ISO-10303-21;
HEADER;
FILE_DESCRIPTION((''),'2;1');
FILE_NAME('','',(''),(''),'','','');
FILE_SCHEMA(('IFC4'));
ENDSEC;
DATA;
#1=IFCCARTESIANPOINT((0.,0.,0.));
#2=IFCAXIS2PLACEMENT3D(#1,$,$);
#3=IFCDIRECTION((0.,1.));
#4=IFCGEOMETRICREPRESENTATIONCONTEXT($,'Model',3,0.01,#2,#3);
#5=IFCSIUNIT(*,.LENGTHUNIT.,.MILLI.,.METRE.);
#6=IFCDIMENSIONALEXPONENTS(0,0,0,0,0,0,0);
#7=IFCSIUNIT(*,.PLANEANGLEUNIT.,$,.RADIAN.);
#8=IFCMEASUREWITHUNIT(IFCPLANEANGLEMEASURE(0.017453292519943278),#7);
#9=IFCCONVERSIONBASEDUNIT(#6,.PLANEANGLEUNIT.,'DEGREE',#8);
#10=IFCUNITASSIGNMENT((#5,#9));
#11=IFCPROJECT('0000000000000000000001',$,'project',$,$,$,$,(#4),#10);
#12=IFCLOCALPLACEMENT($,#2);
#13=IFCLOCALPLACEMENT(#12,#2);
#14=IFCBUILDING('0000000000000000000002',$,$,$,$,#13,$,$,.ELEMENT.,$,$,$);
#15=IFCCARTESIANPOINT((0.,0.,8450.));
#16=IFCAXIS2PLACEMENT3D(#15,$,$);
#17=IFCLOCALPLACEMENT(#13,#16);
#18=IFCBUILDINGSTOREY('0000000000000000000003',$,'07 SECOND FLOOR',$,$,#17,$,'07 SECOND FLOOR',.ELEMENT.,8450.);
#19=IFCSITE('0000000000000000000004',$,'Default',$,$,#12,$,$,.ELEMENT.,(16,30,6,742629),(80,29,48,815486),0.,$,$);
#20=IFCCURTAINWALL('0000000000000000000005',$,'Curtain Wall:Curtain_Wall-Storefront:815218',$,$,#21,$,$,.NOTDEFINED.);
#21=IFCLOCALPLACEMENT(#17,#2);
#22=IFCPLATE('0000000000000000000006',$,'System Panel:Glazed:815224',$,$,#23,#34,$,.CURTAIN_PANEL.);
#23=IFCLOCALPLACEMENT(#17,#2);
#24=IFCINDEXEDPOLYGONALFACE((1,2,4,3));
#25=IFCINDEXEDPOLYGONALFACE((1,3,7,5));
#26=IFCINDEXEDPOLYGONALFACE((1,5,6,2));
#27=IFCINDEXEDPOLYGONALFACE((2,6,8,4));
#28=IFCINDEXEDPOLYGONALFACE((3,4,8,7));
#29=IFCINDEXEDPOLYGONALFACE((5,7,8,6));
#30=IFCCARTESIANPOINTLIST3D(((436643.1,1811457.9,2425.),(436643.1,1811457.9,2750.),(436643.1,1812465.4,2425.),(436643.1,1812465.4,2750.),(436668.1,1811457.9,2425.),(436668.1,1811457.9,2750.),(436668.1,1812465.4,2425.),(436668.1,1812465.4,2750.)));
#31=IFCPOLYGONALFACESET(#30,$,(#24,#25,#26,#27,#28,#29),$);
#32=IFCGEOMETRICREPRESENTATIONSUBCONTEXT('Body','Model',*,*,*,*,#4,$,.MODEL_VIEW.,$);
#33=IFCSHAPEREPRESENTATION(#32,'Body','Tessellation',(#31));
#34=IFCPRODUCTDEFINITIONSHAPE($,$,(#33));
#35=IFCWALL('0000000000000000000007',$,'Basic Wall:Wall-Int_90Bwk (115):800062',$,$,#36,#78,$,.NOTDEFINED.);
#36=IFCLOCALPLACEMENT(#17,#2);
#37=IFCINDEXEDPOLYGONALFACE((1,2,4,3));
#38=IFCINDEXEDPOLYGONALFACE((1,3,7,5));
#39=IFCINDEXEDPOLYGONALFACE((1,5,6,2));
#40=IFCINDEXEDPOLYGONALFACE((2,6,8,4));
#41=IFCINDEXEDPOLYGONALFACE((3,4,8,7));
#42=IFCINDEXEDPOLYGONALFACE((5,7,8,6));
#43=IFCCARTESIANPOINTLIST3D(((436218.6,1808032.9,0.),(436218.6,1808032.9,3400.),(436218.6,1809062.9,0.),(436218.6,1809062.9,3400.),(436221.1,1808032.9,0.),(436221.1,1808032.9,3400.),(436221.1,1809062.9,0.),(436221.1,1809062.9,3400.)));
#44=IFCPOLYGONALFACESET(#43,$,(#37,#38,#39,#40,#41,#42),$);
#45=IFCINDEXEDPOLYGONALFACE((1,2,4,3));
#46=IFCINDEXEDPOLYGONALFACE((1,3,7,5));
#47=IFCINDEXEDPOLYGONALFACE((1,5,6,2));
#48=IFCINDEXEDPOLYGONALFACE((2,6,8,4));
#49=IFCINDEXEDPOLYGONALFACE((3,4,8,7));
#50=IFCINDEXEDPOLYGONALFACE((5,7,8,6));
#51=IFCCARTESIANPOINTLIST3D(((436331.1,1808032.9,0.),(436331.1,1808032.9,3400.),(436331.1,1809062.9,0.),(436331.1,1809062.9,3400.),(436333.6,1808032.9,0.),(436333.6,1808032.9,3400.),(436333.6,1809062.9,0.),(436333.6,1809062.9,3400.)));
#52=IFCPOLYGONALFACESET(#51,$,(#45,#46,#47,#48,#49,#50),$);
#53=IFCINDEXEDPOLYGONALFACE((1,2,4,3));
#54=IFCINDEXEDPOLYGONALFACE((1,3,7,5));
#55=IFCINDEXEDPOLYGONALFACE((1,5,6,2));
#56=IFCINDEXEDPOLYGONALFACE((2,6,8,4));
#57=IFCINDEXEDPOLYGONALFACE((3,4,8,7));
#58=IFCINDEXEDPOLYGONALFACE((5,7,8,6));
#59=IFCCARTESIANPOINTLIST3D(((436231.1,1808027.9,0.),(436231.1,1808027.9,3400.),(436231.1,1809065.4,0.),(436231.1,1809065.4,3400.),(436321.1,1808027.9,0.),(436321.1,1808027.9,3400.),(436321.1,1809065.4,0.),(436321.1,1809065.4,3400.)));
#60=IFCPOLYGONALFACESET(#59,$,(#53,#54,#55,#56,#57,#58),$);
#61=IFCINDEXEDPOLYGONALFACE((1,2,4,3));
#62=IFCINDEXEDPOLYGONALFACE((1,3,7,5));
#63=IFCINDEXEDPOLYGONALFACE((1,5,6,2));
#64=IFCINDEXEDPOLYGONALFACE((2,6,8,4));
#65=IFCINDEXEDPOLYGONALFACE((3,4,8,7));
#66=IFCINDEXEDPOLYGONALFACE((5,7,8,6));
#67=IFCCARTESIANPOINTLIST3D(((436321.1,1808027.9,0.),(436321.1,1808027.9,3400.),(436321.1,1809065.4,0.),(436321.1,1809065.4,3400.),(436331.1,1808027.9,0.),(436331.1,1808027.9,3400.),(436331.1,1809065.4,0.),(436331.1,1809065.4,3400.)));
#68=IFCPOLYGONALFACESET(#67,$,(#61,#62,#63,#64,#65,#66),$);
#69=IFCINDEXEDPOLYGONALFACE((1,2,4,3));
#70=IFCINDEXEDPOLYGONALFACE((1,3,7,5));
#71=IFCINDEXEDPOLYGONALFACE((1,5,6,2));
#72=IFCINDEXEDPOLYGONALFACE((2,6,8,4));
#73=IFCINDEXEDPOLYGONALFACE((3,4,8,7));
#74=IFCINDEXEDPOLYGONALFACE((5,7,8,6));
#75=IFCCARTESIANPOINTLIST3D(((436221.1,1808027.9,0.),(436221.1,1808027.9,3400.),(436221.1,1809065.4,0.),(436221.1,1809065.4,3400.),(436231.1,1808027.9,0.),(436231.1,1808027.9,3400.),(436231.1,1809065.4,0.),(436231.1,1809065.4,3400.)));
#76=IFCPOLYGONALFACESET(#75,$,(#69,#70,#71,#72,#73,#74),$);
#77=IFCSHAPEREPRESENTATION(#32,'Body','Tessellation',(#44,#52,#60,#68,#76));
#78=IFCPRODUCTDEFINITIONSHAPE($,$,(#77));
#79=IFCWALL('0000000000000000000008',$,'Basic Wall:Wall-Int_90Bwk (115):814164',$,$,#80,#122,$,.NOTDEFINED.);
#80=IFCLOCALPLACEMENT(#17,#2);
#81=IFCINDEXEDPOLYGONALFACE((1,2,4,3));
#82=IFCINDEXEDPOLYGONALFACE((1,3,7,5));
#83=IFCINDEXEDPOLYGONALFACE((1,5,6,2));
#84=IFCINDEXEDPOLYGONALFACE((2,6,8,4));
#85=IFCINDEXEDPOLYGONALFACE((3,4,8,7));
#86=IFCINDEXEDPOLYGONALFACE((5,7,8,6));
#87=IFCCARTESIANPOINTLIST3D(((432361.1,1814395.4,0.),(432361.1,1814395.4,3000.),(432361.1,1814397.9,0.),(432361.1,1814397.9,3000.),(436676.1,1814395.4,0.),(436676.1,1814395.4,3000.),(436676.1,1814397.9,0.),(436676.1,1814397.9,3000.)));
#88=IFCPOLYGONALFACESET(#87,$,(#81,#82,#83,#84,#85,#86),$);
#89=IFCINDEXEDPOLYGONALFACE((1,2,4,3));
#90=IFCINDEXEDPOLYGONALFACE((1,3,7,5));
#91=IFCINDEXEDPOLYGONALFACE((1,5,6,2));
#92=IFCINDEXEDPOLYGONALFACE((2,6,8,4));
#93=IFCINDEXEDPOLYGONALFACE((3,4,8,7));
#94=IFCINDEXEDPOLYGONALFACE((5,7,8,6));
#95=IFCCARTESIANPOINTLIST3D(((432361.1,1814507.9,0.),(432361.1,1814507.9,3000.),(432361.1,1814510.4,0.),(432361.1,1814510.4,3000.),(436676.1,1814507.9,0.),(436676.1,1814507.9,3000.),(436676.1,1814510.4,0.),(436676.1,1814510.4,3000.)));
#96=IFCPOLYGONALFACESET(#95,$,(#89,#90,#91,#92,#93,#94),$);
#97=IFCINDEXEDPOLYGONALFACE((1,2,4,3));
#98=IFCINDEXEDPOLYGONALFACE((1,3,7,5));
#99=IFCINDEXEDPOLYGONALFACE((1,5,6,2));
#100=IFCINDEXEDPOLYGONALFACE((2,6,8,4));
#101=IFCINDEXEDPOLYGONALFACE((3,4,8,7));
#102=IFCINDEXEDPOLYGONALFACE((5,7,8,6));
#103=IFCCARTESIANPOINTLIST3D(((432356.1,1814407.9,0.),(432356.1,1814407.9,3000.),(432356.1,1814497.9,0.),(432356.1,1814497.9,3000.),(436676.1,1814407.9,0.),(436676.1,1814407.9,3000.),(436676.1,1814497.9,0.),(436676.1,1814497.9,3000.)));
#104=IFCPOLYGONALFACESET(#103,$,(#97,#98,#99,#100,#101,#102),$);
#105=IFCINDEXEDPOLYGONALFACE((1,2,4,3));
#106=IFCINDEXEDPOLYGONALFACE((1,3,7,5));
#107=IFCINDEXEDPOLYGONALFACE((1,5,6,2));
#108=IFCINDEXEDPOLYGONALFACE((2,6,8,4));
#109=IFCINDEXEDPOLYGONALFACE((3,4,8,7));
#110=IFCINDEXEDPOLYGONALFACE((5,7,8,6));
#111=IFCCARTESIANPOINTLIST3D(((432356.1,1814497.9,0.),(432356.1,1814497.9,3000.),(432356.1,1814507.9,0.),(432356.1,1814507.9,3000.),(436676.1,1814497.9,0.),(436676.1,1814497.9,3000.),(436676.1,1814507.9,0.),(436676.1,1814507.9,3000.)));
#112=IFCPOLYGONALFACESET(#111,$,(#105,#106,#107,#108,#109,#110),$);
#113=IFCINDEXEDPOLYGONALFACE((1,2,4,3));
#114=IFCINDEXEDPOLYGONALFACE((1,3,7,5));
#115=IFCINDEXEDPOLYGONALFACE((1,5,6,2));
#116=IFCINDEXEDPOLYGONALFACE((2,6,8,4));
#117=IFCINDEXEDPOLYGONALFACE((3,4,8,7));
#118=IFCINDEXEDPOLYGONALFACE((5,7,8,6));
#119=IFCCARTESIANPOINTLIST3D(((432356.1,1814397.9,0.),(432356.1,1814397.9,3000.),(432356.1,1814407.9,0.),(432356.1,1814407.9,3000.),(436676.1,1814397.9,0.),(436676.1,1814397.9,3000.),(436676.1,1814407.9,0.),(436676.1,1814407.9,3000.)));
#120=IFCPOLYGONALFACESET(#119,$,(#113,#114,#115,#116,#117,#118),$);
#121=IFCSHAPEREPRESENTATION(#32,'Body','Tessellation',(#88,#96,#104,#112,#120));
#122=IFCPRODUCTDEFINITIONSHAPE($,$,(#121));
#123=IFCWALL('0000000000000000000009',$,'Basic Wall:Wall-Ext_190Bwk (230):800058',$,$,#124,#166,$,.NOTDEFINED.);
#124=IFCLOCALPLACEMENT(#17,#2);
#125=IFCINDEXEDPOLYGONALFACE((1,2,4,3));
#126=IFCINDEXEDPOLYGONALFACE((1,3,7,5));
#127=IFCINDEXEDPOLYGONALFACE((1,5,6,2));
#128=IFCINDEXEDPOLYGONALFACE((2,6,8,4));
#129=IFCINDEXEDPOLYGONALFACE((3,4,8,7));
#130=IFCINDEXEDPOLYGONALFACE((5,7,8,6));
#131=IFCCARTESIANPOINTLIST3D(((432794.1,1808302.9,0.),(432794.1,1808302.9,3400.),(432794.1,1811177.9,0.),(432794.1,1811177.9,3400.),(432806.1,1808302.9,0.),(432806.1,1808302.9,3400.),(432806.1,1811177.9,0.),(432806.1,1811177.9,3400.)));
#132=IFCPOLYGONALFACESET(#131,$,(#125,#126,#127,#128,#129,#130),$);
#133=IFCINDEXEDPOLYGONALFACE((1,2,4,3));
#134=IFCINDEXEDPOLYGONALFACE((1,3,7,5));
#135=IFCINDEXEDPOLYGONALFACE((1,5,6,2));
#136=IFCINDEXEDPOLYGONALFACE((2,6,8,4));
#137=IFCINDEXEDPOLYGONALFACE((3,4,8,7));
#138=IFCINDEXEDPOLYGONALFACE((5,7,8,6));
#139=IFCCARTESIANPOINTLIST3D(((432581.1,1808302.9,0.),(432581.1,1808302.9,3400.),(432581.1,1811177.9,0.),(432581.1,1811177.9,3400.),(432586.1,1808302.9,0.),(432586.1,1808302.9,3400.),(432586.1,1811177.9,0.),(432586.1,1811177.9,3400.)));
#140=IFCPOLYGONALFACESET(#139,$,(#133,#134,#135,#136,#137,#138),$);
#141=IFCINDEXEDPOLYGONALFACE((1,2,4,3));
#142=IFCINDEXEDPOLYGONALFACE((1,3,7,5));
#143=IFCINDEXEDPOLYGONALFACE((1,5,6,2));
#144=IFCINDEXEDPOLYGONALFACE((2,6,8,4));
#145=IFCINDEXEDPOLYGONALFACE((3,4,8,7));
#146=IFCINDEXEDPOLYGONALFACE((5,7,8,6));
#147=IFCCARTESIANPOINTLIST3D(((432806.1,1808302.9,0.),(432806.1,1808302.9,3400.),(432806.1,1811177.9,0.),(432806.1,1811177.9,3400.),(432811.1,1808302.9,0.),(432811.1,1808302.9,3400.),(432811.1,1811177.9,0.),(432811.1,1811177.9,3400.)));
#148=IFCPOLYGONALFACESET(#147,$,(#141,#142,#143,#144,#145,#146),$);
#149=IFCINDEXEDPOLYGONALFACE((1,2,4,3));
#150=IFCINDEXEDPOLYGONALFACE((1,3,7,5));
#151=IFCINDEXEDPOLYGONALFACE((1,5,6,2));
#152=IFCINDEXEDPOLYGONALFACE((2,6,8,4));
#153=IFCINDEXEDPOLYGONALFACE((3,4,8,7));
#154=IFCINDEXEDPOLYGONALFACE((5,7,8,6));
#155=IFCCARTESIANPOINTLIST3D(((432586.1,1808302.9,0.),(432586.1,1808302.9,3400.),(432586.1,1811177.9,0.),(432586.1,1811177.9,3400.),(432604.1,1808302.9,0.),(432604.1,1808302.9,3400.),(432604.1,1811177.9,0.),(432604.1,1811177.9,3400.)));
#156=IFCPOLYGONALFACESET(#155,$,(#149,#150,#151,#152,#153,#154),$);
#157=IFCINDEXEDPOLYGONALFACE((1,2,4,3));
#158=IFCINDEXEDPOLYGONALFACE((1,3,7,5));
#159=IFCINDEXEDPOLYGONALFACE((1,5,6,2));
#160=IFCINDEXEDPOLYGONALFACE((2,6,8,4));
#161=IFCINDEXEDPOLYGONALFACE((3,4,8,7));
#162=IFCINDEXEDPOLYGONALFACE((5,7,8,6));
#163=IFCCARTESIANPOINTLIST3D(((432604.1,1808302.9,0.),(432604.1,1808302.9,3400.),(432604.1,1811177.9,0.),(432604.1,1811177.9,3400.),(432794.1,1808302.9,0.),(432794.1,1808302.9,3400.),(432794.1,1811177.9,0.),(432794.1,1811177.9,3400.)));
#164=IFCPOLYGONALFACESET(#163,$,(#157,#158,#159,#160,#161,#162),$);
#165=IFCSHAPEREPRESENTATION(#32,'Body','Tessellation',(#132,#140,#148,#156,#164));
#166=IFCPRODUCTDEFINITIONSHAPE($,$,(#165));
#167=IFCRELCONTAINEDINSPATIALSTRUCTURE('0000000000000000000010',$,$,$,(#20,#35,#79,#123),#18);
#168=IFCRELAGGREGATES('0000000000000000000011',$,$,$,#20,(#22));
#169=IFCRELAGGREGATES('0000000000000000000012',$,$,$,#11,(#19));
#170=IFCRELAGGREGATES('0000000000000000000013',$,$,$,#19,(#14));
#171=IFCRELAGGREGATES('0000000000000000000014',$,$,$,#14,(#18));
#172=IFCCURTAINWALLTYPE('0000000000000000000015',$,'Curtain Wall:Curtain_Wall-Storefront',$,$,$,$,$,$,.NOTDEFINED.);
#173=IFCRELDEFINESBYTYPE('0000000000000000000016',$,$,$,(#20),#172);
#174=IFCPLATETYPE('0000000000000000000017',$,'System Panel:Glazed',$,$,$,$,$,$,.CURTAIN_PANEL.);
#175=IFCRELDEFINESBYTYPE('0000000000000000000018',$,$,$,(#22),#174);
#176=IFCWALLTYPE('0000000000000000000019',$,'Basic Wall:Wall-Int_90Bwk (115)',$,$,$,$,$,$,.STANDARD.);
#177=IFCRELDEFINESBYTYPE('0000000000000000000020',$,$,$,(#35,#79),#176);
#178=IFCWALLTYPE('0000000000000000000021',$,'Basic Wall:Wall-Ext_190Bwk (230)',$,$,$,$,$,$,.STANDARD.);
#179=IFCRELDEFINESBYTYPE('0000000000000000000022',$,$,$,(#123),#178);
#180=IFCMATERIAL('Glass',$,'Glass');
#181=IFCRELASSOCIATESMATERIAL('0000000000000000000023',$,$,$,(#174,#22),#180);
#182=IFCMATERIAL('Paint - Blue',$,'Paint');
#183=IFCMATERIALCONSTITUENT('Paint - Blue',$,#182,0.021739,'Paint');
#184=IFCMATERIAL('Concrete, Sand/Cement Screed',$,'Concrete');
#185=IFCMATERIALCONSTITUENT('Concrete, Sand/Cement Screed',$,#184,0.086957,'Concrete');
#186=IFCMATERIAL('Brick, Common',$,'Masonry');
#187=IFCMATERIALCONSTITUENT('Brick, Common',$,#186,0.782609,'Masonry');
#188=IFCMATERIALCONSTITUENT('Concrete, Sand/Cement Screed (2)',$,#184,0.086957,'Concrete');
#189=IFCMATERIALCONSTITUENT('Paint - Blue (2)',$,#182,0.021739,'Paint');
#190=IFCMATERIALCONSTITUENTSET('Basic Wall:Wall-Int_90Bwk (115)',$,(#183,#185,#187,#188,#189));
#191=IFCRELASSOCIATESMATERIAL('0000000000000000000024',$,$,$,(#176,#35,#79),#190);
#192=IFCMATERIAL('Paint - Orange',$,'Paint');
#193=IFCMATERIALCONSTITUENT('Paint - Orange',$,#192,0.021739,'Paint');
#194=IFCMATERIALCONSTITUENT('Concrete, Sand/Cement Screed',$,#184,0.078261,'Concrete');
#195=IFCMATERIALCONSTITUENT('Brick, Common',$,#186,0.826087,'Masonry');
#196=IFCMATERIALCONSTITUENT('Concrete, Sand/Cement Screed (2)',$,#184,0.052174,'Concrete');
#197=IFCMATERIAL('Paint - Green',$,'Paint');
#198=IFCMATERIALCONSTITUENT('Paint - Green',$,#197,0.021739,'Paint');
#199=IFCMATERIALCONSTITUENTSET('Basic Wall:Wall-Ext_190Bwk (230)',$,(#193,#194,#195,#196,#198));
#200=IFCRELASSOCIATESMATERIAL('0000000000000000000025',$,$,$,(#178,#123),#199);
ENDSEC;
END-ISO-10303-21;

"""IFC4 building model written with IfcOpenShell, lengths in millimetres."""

from ifc_helpers import new_model, entity, si_unit, converted_unit, direction, frame, origin, place, context, subcontext, project, spatial, indexed_curve, outline, extrude, source, transform, mapped, material, constituent, constituent_set, type_object, type_shapes, element, aggregate, save


model = new_model("IFC4")

# Units and contexts
model_context = context("Model", 3, precision=0.01, world=origin(), true_north=direction((0.0, 1.0)))
body_context = subcontext(model_context, "Body", "Model", "MODEL_VIEW")
ifc_project = project(units=[si_unit("LENGTHUNIT", "METRE", prefix="MILLI"), converted_unit("PLANEANGLEUNIT", "DEGREE", entity("IfcPlaneAngleMeasure", 0.017453292519943278), si_unit("PLANEANGLEUNIT", "RADIAN"), dimensions=[0, 0, 0, 0, 0, 0, 0])], contexts=[model_context])

# Site, building, storey
site_placement = place(None, origin())
site = spatial("IfcSite", under=ifc_project, at=site_placement, Name="Default", CompositionType="ELEMENT", RefLatitude=(16, 30, 6, 742629), RefLongitude=(80, 29, 48, 815486), RefElevation=0.0)
building_placement = place(site_placement, origin())
building = spatial("IfcBuilding", under=site, at=building_placement, CompositionType="ELEMENT")
storey_placement = place(building_placement, frame((0.0, 0.0, 8450.0)))
storey = spatial("IfcBuildingStorey", under=building, at=storey_placement, Name="07 SECOND FLOOR", LongName="07 SECOND FLOOR", CompositionType="ELEMENT", Elevation=8450.0)

# Curtain wall, plate
curtain_wall_type = type_object("IfcCurtainWallType", Name="Curtain Wall:Curtain_Wall-Storefront", PredefinedType="NOTDEFINED")
curtain_wall_placement = place(storey_placement, frame((0.0, 0.0, -8450.0)))
curtain_wall = element("IfcCurtainWall", 1, at=curtain_wall_placement, inside=storey, type_object=curtain_wall_type, Name="Curtain Wall:Curtain_Wall-Storefront:815218", PredefinedType="NOTDEFINED")
ifc_material_1 = material(Name="Glass", Category="Glass")
plate_type_1 = type_object("IfcPlateType", Name="System Panel:Glazed", PredefinedType="CURTAIN_PANEL", material=ifc_material_1)
shared_shape_1 = source(origin(), body_context, "Body", "SweptSolid", [
    extrude(outline(indexed_curve([(-12.5, -503.8), (12.5, -503.8), (12.5, 503.8), (-12.5, 503.8), (-12.5, -503.8)], self_intersect=False)), frame((0.0, 37.0, 0.0), z_axis=(0.0, 0.0, 1.0), x_axis=(0.0, 1.0, 0.0)), (0.0, 0.0, 1.0), 325.0),
])
type_shapes(plate_type_1, [shared_shape_1])
plate_1_placement = place(curtain_wall_placement, frame((436618.6, 1811961.7, 10875.0), z_axis=(0.0, 0.0, 1.0), x_axis=(0.0, -1.0, 0.0)))
plate_1 = element("IfcPlate", 2, at=plate_1_placement, type_object=plate_type_1, material=ifc_material_1, Name="System Panel:Glazed:815224", PredefinedType="CURTAIN_PANEL", context=body_context, shape_type="MappedRepresentation", body=[
    mapped(shared_shape_1, transform((0.0, 0.0, 0.0), scale=1.0)),
])

# Shared definitions
ifc_material_2 = material(Name="Paint - Blue", Category="Paint")
ifc_constituent_1 = constituent(ifc_material_2, Name="Paint - Blue", Category="Paint", fraction=0.021739)
ifc_material_3 = material(Name="Concrete, Sand/Cement Screed", Category="Concrete")
ifc_constituent_2 = constituent(ifc_material_3, Name="Concrete, Sand/Cement Screed", Category="Concrete", fraction=0.086957)
ifc_material_4 = material(Name="Brick, Common", Category="Masonry")
ifc_constituent_3 = constituent(ifc_material_4, Name="Brick, Common", Category="Masonry", fraction=0.782609)
ifc_constituent_4 = constituent(ifc_material_3, Name="Concrete, Sand/Cement Screed (2)", Category="Concrete", fraction=0.086957)
ifc_constituent_5 = constituent(ifc_material_2, Name="Paint - Blue (2)", Category="Paint", fraction=0.021739)
ifc_constituent_set_1 = constituent_set(constituents=[ifc_constituent_1, ifc_constituent_2, ifc_constituent_3, ifc_constituent_4, ifc_constituent_5], Name="Basic Wall:Wall-Int_90Bwk (115)")
wall_type_1 = type_object("IfcWallType", Name="Basic Wall:Wall-Int_90Bwk (115)", PredefinedType="STANDARD", material=ifc_constituent_set_1)

# Walls
wall_1_placement = place(storey_placement, frame((436276.1, 1809062.9, 0.0), z_axis=(0.0, 0.0, 1.0), x_axis=(0.0, -1.0, 0.0)))
element("IfcWall", 3, at=wall_1_placement, inside=storey, type_object=wall_type_1, material=ifc_constituent_set_1, Name="Basic Wall:Wall-Int_90Bwk (115):800062", PredefinedType="NOTDEFINED", context=body_context, shape_type="SweptSolid", body=[
    extrude(outline(indexed_curve([(-1.3, -515.0), (1.2, -515.0), (1.2, 515.0), (-1.3, 515.0), (-1.3, -515.0)], self_intersect=False)), frame((515.0, -56.2, 0.0), z_axis=(0.0, 0.0, 1.0), x_axis=(0.0, 1.0, 0.0)), (0.0, 0.0, 1.0), 3400.0),
    extrude(outline(indexed_curve([(-1.2, -515.0), (1.3, -515.0), (1.3, 515.0), (-1.2, 515.0), (-1.2, -515.0)], self_intersect=False)), frame((515.0, 56.3, 0.0), z_axis=(0.0, 0.0, 1.0), x_axis=(0.0, -1.0, 0.0)), (0.0, 0.0, 1.0), 3400.0),
    extrude(outline(indexed_curve([(-518.8, -45.0), (518.8, -45.0), (518.8, 45.0), (-518.8, 45.0), (-518.8, -45.0)], self_intersect=False)), frame((516.3, 0.0, 0.0)), (0.0, 0.0, 1.0), 3400.0),
    extrude(outline(indexed_curve([(-518.8, -5.0), (518.8, -5.0), (518.8, 5.0), (-518.8, 5.0), (-518.8, -5.0)], self_intersect=False)), frame((516.3, 50.0, 0.0)), (0.0, 0.0, 1.0), 3400.0),
    extrude(outline(indexed_curve([(-518.8, -5.0), (518.8, -5.0), (518.8, 5.0), (-518.8, 5.0), (-518.8, -5.0)], self_intersect=False)), frame((516.3, -50.0, 0.0)), (0.0, 0.0, 1.0), 3400.0),
])
wall_2_placement = place(storey_placement, frame((432361.1, 1814452.9, 0.0)))
element("IfcWall", 4, at=wall_2_placement, inside=storey, type_object=wall_type_1, material=ifc_constituent_set_1, Name="Basic Wall:Wall-Int_90Bwk (115):814164", PredefinedType="NOTDEFINED", context=body_context, shape_type="SweptSolid", body=[
    extrude(outline(indexed_curve([(-1.2, -2157.5), (1.3, -2157.5), (1.3, 2157.5), (-1.2, 2157.5), (-1.2, -2157.5)], self_intersect=False)), frame((2157.5, -56.3, 0.0), z_axis=(0.0, 0.0, 1.0), x_axis=(0.0, 1.0, 0.0)), (0.0, 0.0, 1.0), 3000.0),
    extrude(outline(indexed_curve([(-1.3, -2157.5), (1.3, -2157.5), (1.3, 2157.5), (-1.3, 2157.5), (-1.3, -2157.5)], self_intersect=False)), frame((2157.5, 56.3, 0.0), z_axis=(0.0, 0.0, 1.0), x_axis=(0.0, -1.0, 0.0)), (0.0, 0.0, 1.0), 3000.0),
    extrude(outline(indexed_curve([(-2160.0, -45.0), (2160.0, -45.0), (2160.0, 45.0), (-2160.0, 45.0), (-2160.0, -45.0)], self_intersect=False)), frame((2155.0, 0.0, 0.0)), (0.0, 0.0, 1.0), 3000.0),
    extrude(outline(indexed_curve([(-2160.0, -5.0), (2160.0, -5.0), (2160.0, 5.0), (-2160.0, 5.0), (-2160.0, -5.0)], self_intersect=False)), frame((2155.0, 50.0, 0.0)), (0.0, 0.0, 1.0), 3000.0),
    extrude(outline(indexed_curve([(-2160.0, -5.0), (2160.0, -5.0), (2160.0, 5.0), (-2160.0, 5.0), (-2160.0, -5.0)], self_intersect=False)), frame((2155.0, -50.0, 0.0)), (0.0, 0.0, 1.0), 3000.0),
])

# Shared definitions
ifc_material_5 = material(Name="Paint - Orange", Category="Paint")
ifc_constituent_6 = constituent(ifc_material_5, Name="Paint - Orange", Category="Paint", fraction=0.021739)
ifc_constituent_7 = constituent(ifc_material_3, Name="Concrete, Sand/Cement Screed", Category="Concrete", fraction=0.078261)
ifc_constituent_8 = constituent(ifc_material_4, Name="Brick, Common", Category="Masonry", fraction=0.826087)
ifc_constituent_9 = constituent(ifc_material_3, Name="Concrete, Sand/Cement Screed (2)", Category="Concrete", fraction=0.052174)
ifc_material_6 = material(Name="Paint - Green", Category="Paint")
ifc_constituent_10 = constituent(ifc_material_6, Name="Paint - Green", Category="Paint", fraction=0.021739)
ifc_constituent_set_2 = constituent_set(constituents=[ifc_constituent_6, ifc_constituent_7, ifc_constituent_8, ifc_constituent_9, ifc_constituent_10], Name="Basic Wall:Wall-Ext_190Bwk (230)")
wall_type_2 = type_object("IfcWallType", Name="Basic Wall:Wall-Ext_190Bwk (230)", PredefinedType="STANDARD", material=ifc_constituent_set_2)

# Wall
wall_3_placement = place(storey_placement, frame((432696.1, 1808302.9, 0.0), z_axis=(0.0, 0.0, 1.0), x_axis=(0.0, 1.0, 0.0)))
element("IfcWall", 5, at=wall_3_placement, inside=storey, type_object=wall_type_2, material=ifc_constituent_set_2, Name="Basic Wall:Wall-Ext_190Bwk (230):800058", PredefinedType="NOTDEFINED", context=body_context, shape_type="SweptSolid", body=[
    extrude(outline(indexed_curve([(-1437.5, -6.0), (1437.5, -6.0), (1437.5, 6.0), (-1437.5, 6.0), (-1437.5, -6.0)], self_intersect=False)), frame((1437.5, -104.0, 0.0)), (0.0, 0.0, 1.0), 3400.0),
    extrude(outline(indexed_curve([(-2.5, -1437.5), (2.5, -1437.5), (2.5, 1437.5), (-2.5, 1437.5), (-2.5, -1437.5)], self_intersect=False)), frame((1437.5, 112.5, 0.0), z_axis=(0.0, 0.0, 1.0), x_axis=(0.0, -1.0, 0.0)), (0.0, 0.0, 1.0), 3400.0),
    extrude(outline(indexed_curve([(-2.5, -1437.5), (2.5, -1437.5), (2.5, 1437.5), (-2.5, 1437.5), (-2.5, -1437.5)], self_intersect=False)), frame((1437.5, -112.5, 0.0), z_axis=(0.0, 0.0, 1.0), x_axis=(0.0, 1.0, 0.0)), (0.0, 0.0, 1.0), 3400.0),
    extrude(outline(indexed_curve([(-1437.5, -9.0), (1437.5, -9.0), (1437.5, 9.0), (-1437.5, 9.0), (-1437.5, -9.0)], self_intersect=False)), frame((1437.5, 101.0, 0.0)), (0.0, 0.0, 1.0), 3400.0),
    extrude(outline(indexed_curve([(-1437.5, -95.0), (1437.5, -95.0), (1437.5, 95.0), (-1437.5, 95.0), (-1437.5, -95.0)], self_intersect=False)), frame((1437.5, -3.0, 0.0)), (0.0, 0.0, 1.0), 3400.0),
])

aggregate(curtain_wall, [plate_1])

save(model, "model.ifc")
